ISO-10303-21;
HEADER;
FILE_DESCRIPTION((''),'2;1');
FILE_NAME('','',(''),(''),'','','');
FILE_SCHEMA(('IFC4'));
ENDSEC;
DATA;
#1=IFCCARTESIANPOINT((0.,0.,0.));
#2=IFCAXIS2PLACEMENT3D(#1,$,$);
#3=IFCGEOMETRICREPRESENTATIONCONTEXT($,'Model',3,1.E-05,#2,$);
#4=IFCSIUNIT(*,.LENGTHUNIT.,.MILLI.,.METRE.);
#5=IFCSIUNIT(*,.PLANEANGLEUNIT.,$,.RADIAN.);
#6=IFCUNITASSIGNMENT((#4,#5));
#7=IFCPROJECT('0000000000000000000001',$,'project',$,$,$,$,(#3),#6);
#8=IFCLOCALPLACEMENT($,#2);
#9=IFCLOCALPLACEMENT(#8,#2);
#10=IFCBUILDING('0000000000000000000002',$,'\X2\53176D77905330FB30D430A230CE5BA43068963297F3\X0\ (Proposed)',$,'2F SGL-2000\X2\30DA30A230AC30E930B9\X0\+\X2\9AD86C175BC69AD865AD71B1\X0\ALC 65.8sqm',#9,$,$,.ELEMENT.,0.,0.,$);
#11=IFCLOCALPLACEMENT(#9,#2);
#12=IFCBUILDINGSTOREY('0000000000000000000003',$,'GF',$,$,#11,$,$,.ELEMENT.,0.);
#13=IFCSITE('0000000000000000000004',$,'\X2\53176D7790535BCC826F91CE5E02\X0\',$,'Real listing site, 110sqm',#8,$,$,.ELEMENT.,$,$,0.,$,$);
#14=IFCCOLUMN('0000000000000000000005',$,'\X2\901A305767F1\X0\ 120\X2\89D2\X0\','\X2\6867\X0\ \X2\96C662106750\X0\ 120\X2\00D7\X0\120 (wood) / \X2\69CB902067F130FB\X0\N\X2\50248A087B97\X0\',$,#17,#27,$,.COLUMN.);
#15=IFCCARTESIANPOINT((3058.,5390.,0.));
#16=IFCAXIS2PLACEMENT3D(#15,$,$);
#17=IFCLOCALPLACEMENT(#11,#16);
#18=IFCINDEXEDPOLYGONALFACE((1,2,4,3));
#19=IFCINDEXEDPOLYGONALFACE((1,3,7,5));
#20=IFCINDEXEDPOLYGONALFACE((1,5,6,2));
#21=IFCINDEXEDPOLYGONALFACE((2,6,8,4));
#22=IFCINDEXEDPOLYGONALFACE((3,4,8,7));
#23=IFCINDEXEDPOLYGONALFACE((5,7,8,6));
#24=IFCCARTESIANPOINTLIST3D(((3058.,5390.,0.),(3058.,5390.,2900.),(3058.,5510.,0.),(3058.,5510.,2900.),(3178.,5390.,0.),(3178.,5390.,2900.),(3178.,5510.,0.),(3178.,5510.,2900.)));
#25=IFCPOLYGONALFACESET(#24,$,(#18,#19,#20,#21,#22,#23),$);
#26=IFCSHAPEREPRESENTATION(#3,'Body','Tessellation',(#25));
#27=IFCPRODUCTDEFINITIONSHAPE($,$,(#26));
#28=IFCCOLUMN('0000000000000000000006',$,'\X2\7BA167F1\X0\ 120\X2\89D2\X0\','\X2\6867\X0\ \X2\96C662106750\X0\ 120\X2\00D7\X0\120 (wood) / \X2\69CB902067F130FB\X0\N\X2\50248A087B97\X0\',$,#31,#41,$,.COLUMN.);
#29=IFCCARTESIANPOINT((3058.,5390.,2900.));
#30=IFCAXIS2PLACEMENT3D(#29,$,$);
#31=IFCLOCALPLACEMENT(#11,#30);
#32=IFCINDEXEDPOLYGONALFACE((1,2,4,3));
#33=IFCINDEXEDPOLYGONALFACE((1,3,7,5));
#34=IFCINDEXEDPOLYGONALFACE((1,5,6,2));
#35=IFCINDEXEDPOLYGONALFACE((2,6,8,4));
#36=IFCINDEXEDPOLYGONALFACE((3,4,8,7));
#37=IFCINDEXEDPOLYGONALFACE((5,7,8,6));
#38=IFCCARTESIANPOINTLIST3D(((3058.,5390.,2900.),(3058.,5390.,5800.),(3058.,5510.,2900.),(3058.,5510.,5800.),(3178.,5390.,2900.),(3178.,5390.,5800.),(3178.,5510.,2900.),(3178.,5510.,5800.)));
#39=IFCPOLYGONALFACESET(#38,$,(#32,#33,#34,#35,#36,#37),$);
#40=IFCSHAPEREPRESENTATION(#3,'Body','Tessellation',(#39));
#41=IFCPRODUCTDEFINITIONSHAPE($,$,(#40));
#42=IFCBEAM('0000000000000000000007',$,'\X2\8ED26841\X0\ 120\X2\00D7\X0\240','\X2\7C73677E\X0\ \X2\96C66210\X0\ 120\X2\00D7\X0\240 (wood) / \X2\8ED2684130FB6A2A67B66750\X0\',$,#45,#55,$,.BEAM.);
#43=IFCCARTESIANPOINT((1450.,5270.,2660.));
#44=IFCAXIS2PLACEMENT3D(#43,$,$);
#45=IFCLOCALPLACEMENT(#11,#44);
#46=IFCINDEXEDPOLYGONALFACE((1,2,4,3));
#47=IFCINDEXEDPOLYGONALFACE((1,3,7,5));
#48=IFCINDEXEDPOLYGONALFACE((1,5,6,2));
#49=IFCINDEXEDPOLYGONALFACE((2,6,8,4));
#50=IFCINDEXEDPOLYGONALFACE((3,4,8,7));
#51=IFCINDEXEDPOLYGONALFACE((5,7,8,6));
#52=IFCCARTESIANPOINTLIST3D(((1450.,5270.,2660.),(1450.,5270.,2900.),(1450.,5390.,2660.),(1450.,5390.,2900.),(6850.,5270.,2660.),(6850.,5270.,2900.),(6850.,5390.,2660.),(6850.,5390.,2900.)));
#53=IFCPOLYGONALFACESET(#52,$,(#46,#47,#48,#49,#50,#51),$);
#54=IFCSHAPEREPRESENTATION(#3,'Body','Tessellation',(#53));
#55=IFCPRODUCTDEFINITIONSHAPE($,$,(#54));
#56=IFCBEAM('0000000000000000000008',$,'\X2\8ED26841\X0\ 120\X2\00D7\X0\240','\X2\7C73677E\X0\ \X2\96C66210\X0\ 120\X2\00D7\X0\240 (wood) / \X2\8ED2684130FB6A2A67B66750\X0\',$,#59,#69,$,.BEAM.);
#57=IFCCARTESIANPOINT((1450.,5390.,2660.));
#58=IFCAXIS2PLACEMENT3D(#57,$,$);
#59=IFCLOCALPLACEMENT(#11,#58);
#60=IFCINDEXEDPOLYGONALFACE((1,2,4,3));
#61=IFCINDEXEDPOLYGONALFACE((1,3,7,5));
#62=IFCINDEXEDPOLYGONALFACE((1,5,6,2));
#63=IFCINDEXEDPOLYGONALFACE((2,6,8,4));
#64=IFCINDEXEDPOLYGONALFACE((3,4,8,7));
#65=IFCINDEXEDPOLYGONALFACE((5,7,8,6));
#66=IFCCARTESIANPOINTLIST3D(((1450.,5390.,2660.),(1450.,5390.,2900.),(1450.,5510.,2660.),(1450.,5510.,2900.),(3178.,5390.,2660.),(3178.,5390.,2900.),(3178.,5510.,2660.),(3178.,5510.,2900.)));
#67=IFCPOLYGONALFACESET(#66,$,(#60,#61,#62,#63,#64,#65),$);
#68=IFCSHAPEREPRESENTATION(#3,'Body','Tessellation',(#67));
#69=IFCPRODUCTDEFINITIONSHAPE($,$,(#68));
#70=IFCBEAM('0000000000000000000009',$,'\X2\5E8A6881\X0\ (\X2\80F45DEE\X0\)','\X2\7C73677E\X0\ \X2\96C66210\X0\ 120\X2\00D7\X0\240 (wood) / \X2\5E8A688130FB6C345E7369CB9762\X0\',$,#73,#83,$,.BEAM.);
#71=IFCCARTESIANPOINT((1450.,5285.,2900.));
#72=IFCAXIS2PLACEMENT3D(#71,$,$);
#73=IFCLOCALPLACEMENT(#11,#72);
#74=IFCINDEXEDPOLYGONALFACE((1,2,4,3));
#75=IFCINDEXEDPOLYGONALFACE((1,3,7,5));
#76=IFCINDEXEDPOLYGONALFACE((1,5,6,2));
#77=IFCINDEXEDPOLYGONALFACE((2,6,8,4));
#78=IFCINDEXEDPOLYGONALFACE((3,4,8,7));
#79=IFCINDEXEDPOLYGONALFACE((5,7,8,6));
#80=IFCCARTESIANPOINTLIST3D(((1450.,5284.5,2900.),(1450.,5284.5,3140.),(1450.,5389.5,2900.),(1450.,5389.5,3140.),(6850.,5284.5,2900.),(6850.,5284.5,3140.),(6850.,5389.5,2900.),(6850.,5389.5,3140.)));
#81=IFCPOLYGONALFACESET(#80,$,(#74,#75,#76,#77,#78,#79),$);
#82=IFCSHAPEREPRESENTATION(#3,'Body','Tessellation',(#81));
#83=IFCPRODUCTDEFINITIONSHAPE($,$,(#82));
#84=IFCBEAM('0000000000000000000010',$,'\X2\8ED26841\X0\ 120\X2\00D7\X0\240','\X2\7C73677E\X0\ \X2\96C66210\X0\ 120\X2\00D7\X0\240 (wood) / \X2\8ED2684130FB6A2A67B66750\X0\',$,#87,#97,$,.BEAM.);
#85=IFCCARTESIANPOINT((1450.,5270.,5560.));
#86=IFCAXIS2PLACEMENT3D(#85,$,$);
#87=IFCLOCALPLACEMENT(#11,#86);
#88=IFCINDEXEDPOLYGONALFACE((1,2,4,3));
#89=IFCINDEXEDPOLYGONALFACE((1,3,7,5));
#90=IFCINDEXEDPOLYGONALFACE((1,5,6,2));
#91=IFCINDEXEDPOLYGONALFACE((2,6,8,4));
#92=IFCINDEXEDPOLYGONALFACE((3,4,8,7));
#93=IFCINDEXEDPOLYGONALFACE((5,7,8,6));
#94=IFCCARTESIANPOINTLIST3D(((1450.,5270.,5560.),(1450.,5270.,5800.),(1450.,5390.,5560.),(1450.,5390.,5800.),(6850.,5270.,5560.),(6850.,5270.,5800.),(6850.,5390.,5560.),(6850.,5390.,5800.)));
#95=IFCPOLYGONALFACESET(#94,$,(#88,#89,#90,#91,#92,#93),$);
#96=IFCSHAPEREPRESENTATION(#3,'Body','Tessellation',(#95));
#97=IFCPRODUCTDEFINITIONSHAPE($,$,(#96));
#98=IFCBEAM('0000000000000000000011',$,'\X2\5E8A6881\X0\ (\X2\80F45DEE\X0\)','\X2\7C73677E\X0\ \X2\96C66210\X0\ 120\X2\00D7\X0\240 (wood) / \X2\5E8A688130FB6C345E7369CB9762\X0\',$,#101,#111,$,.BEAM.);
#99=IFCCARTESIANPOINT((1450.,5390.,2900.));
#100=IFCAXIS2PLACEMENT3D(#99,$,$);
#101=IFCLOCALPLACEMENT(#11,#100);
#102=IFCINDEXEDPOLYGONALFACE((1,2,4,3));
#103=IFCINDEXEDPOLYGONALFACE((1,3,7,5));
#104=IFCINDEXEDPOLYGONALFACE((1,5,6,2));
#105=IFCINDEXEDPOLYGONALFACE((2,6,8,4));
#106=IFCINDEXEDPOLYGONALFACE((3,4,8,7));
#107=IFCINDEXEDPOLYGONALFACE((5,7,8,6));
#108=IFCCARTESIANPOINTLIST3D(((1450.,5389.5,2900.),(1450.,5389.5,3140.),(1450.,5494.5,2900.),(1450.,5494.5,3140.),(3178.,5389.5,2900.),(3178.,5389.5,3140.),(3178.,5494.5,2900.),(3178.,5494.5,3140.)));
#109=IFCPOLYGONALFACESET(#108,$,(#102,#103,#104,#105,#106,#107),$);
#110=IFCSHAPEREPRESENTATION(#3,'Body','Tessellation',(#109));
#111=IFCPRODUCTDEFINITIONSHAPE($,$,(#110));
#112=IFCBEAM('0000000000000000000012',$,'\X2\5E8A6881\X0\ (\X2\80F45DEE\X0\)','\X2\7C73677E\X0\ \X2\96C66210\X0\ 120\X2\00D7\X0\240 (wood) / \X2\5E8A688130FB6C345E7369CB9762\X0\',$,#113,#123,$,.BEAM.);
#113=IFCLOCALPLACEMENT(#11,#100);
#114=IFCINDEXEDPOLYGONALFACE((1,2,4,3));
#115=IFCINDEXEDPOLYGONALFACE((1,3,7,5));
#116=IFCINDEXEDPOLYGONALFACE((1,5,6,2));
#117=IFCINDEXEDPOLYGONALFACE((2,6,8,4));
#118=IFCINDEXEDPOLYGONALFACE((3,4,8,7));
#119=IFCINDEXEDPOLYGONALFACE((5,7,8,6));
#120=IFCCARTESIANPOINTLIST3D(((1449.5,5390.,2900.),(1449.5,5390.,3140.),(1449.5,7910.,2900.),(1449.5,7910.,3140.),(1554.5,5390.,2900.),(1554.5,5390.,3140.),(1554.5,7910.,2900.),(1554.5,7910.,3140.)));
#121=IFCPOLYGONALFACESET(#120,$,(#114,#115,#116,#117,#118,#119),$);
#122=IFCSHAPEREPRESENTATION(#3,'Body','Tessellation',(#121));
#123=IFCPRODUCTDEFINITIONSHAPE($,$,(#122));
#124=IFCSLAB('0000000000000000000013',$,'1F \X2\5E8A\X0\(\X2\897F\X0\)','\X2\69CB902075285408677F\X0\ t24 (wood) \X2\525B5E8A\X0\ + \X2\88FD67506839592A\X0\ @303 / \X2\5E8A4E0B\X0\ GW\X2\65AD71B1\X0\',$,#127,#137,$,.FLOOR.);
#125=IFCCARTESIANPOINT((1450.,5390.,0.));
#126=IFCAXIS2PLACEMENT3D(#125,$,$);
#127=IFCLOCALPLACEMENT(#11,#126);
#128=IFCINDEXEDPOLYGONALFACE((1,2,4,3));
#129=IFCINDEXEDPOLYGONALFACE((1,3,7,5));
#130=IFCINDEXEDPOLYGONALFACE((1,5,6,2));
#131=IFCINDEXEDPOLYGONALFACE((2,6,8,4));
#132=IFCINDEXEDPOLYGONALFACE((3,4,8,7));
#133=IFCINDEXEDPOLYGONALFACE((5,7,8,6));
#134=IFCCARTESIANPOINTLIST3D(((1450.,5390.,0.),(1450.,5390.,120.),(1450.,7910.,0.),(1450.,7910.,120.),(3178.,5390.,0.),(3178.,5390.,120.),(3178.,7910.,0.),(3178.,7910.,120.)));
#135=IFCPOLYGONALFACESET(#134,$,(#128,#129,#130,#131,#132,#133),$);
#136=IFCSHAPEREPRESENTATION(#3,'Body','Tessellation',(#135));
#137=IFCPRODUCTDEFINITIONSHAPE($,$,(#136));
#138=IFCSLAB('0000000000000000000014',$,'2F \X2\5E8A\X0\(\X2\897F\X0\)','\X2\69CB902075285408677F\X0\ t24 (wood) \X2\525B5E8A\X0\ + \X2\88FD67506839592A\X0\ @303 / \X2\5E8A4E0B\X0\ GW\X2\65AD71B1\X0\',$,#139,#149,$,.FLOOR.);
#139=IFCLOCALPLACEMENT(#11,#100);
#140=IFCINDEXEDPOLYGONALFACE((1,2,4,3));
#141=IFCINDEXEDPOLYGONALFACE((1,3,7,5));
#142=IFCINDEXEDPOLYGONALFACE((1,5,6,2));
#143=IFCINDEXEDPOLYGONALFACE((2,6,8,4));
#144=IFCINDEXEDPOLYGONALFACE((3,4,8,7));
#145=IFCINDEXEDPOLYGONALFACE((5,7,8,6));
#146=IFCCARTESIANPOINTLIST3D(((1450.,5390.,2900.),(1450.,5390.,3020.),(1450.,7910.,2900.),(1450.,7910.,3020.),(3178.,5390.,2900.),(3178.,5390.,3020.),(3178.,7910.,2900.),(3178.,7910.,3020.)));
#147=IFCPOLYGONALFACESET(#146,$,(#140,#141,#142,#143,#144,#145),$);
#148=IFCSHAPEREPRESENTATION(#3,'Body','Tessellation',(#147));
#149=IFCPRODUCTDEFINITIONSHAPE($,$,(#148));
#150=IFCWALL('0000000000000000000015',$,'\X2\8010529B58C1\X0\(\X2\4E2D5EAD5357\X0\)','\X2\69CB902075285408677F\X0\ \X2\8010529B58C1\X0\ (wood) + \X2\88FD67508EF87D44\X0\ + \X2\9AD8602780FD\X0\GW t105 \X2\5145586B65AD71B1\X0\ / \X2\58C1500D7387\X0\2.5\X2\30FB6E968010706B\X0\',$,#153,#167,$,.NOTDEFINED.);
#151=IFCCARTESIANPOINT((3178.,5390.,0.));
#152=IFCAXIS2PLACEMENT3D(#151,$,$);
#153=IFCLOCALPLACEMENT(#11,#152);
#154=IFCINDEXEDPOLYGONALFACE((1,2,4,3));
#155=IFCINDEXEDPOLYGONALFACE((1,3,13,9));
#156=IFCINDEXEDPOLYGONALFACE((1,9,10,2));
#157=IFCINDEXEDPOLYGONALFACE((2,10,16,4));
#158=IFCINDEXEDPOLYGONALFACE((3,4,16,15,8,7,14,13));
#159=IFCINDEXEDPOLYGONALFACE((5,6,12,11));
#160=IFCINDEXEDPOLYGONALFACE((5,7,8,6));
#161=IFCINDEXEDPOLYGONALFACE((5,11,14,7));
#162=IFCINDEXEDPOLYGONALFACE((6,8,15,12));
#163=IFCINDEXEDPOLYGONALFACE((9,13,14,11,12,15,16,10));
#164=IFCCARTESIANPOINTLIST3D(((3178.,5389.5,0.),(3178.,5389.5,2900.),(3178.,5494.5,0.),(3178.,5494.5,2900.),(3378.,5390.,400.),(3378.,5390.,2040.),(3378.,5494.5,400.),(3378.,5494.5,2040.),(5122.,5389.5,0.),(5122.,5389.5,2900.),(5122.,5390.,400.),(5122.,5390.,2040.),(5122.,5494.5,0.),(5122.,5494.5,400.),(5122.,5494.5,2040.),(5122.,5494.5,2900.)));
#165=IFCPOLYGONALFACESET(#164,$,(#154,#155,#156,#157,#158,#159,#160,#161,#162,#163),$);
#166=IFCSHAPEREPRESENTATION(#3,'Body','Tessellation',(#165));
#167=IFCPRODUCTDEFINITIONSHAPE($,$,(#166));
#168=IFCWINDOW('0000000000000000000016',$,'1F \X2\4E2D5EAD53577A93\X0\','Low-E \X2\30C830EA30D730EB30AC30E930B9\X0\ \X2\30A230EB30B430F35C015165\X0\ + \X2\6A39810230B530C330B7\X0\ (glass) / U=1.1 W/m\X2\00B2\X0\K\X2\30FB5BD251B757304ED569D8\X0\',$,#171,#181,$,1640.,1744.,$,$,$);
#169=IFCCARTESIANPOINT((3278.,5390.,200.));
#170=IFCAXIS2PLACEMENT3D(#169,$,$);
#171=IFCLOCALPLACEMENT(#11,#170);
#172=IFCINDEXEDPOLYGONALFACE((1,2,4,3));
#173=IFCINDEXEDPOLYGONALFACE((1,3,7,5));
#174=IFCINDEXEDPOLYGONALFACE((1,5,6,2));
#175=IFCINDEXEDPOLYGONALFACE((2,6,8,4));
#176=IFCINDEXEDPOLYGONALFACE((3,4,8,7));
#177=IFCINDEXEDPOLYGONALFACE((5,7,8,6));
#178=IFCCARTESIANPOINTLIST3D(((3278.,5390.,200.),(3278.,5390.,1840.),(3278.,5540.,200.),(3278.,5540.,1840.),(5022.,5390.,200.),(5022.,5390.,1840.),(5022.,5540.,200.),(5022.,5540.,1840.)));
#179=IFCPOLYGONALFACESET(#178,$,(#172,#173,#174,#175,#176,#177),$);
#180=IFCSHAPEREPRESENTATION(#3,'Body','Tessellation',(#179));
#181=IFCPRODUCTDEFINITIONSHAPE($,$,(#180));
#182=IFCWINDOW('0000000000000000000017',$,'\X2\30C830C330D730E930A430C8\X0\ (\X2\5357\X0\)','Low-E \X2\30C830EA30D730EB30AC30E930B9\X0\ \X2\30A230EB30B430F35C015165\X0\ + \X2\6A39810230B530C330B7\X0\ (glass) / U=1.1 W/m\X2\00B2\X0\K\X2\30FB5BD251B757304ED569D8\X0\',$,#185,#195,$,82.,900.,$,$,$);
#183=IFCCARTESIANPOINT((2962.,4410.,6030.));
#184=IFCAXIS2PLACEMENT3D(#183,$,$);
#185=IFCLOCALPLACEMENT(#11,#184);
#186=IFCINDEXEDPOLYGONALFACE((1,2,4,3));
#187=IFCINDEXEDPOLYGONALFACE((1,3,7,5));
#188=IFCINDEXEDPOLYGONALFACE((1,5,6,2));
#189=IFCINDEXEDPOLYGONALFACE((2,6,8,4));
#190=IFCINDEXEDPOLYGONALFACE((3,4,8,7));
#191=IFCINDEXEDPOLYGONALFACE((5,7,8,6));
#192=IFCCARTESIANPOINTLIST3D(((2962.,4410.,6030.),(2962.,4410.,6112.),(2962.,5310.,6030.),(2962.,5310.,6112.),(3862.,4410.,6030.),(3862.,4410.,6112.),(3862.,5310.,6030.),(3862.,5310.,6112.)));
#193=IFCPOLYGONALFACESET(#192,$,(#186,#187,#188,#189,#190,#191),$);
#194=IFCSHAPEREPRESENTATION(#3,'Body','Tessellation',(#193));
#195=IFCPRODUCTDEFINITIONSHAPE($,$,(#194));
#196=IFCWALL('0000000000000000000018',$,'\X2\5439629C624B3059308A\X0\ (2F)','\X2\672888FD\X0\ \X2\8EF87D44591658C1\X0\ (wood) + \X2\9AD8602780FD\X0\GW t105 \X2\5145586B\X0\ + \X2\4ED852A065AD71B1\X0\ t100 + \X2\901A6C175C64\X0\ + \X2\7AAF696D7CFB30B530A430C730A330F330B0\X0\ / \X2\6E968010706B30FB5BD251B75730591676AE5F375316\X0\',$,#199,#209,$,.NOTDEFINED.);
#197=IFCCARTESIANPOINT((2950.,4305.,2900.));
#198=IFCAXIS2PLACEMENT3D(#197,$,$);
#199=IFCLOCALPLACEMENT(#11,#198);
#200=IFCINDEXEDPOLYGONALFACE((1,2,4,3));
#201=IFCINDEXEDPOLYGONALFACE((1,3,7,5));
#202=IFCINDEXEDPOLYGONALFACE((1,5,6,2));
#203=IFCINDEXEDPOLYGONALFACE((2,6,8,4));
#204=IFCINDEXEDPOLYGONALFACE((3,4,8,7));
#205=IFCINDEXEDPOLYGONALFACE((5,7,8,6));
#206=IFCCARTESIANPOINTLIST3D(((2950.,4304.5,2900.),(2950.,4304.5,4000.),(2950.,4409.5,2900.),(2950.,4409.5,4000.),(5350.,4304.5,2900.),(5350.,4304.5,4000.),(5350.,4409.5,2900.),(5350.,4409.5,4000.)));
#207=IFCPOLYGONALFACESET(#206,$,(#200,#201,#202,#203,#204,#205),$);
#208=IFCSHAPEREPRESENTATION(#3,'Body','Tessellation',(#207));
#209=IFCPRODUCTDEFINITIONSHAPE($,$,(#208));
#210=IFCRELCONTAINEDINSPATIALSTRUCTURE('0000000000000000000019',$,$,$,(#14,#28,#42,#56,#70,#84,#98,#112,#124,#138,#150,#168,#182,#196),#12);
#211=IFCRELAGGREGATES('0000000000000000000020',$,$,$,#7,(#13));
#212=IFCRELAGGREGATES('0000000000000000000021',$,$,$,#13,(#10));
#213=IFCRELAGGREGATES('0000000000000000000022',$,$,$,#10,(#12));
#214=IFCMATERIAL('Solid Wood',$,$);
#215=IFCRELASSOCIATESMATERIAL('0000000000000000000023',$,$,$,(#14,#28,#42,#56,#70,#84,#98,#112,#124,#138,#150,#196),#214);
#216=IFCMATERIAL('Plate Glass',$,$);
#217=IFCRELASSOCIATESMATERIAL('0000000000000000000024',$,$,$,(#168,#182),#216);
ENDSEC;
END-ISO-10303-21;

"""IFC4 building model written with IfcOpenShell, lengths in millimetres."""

from ifc_helpers import new_model, si_unit, frame, frame_2d, origin, place, context, project, spatial, rectangle, extrude, material, element, fill, save


model = new_model("IFC4")

# Units and contexts
model_context = context("Model", 3, precision=1e-05, world=origin())
ifc_project = project(units=[si_unit("LENGTHUNIT", "METRE", prefix="MILLI"), si_unit("PLANEANGLEUNIT", "RADIAN")], contexts=[model_context])

# Site, building, storey
site_placement = place(None, origin())
site = spatial("IfcSite", under=ifc_project, at=site_placement, Name="北海道富良野市", ObjectType="Real listing site, 110sqm", CompositionType="ELEMENT", RefElevation=0.0)
building_placement = place(site_placement, origin())
building = spatial("IfcBuilding", under=site, at=building_placement, Name="北海道・ピアノ室と防音 (Proposed)", ObjectType="2F SGL-2000ペアガラス+高気密高断熱ALC 65.8sqm", CompositionType="ELEMENT", ElevationOfRefHeight=0.0, ElevationOfTerrain=0.0)
storey_placement = place(building_placement, origin())
storey = spatial("IfcBuildingStorey", under=building, at=storey_placement, Name="GF", CompositionType="ELEMENT", Elevation=0.0)

# Columns
ifc_material_1 = material(Name="Solid Wood")
column_1_placement = place(storey_placement, frame((3058.0, 5390.0, 0.0)))
element("IfcColumn", 1, at=column_1_placement, inside=storey, material=ifc_material_1, Name="通し柱 120角", Description="桧 集成材 120×120 (wood) / 構造柱・N値計算", PredefinedType="COLUMN", context=model_context, shape_type="SweptSolid", body=[
    extrude(rectangle(XDim=120.0, YDim=120.0, at=frame_2d((60.0, 60.0))), frame((3058.0, 5390.0, 0.0)), (0.0, 0.0, 1.0), 2900.0),
])
column_2_placement = place(storey_placement, frame((3058.0, 5390.0, 2900.0)))
element("IfcColumn", 2, at=column_2_placement, inside=storey, material=ifc_material_1, Name="管柱 120角", Description="桧 集成材 120×120 (wood) / 構造柱・N値計算", PredefinedType="COLUMN", context=model_context, shape_type="SweptSolid", body=[
    extrude(rectangle(XDim=120.0, YDim=120.0, at=frame_2d((60.0, 60.0))), frame((3058.0, 5390.0, 2900.0)), (0.0, 0.0, 1.0), 2900.0),
])

# Beams
beam_1_placement = place(storey_placement, frame((1450.0, 5270.0, 2660.0)))
element("IfcBeam", 3, at=beam_1_placement, inside=storey, material=ifc_material_1, Name="軒桁 120×240", Description="米松 集成 120×240 (wood) / 軒桁・横架材", PredefinedType="BEAM", context=model_context, shape_type="SweptSolid", body=[
    extrude(rectangle(XDim=5400.0, YDim=120.0, at=frame_2d((2700.0, 60.0))), frame((1450.0, 5270.0, 2660.0)), (0.0, 0.0, 1.0), 240.0),
])
beam_2_placement = place(storey_placement, frame((1450.0, 5390.0, 2660.0)))
element("IfcBeam", 4, at=beam_2_placement, inside=storey, material=ifc_material_1, Name="軒桁 120×240", Description="米松 集成 120×240 (wood) / 軒桁・横架材", PredefinedType="BEAM", context=model_context, shape_type="SweptSolid", body=[
    extrude(rectangle(XDim=1728.0, YDim=120.0, at=frame_2d((864.0, 60.0))), frame((1450.0, 5390.0, 2660.0)), (0.0, 0.0, 1.0), 240.0),
])
beam_3_placement = place(storey_placement, frame((1450.0, 5285.0, 2900.0)))
element("IfcBeam", 5, at=beam_3_placement, inside=storey, material=ifc_material_1, Name="床梁 (胴差)", Description="米松 集成 120×240 (wood) / 床梁・水平構面", PredefinedType="BEAM", context=model_context, shape_type="SweptSolid", body=[
    extrude(rectangle(XDim=5400.0, YDim=105.0, at=frame_2d((2700.0, 52.0))), frame((1450.0, 5285.0, 2900.0)), (0.0, 0.0, 1.0), 240.0),
])
beam_4_placement = place(storey_placement, frame((1450.0, 5270.0, 5560.0)))
element("IfcBeam", 6, at=beam_4_placement, inside=storey, material=ifc_material_1, Name="軒桁 120×240", Description="米松 集成 120×240 (wood) / 軒桁・横架材", PredefinedType="BEAM", context=model_context, shape_type="SweptSolid", body=[
    extrude(rectangle(XDim=5400.0, YDim=120.0, at=frame_2d((2700.0, 60.0))), frame((1450.0, 5270.0, 5560.0)), (0.0, 0.0, 1.0), 240.0),
])
beam_5_placement = place(storey_placement, frame((1450.0, 5390.0, 2900.0)))
element("IfcBeam", 7, at=beam_5_placement, inside=storey, material=ifc_material_1, Name="床梁 (胴差)", Description="米松 集成 120×240 (wood) / 床梁・水平構面", PredefinedType="BEAM", context=model_context, shape_type="SweptSolid", body=[
    extrude(rectangle(XDim=1728.0, YDim=105.0, at=frame_2d((864.0, 52.0))), frame((1450.0, 5390.0, 2900.0)), (0.0, 0.0, 1.0), 240.0),
])
beam_6_placement = place(storey_placement, frame((1450.0, 5390.0, 2900.0)))
element("IfcBeam", 8, at=beam_6_placement, inside=storey, material=ifc_material_1, Name="床梁 (胴差)", Description="米松 集成 120×240 (wood) / 床梁・水平構面", PredefinedType="BEAM", context=model_context, shape_type="SweptSolid", body=[
    extrude(rectangle(XDim=105.0, YDim=2520.0, at=frame_2d((52.0, 1260.0))), frame((1450.0, 5390.0, 2900.0)), (0.0, 0.0, 1.0), 240.0),
])

# Slabs
slab_1_placement = place(storey_placement, frame((1450.0, 5390.0, 0.0)))
element("IfcSlab", 9, at=slab_1_placement, inside=storey, material=ifc_material_1, Name="1F 床(西)", Description="構造用合板 t24 (wood) 剛床 + 製材根太 @303 / 床下 GW断熱", PredefinedType="FLOOR", context=model_context, shape_type="SweptSolid", body=[
    extrude(rectangle(XDim=1728.0, YDim=2520.0, at=frame_2d((864.0, 1260.0))), frame((1450.0, 5390.0, 0.0)), (0.0, 0.0, 1.0), 120.0),
])
slab_2_placement = place(storey_placement, frame((1450.0, 5390.0, 2900.0)))
element("IfcSlab", 10, at=slab_2_placement, inside=storey, material=ifc_material_1, Name="2F 床(西)", Description="構造用合板 t24 (wood) 剛床 + 製材根太 @303 / 床下 GW断熱", PredefinedType="FLOOR", context=model_context, shape_type="SweptSolid", body=[
    extrude(rectangle(XDim=1728.0, YDim=2520.0, at=frame_2d((864.0, 1260.0))), frame((1450.0, 5390.0, 2900.0)), (0.0, 0.0, 1.0), 120.0),
])

# Wall, opening, window
wall_1_placement = place(storey_placement, frame((3178.0, 5390.0, 0.0)))
wall_1 = element("IfcWall", 11, at=wall_1_placement, inside=storey, material=ifc_material_1, Name="耐力壁(中庭南)", Description="構造用合板 耐力壁 (wood) + 製材軸組 + 高性能GW t105 充填断熱 / 壁倍率2.5・準耐火", PredefinedType="NOTDEFINED", context=model_context, shape_type="SweptSolid", body=[
    extrude(rectangle(XDim=1944.0, YDim=105.0, at=frame_2d((972.0, 52.0))), frame((3178.0, 5390.0, 0.0)), (0.0, 0.0, 1.0), 2900.0),
])
opening_placement = place(storey_placement, frame((3278.0, 5390.0, 200.0)))
opening = element("IfcOpeningElement", 12, at=opening_placement, cuts=wall_1, PredefinedType="NOTDEFINED", context=model_context, shape_type="SweptSolid", body=[
    extrude(rectangle(XDim=1744.0, YDim=150.0, at=frame_2d((872.0, 75.0))), frame((3278.0, 5390.0, 200.0)), (0.0, 0.0, 1.0), 1640.0),
])
ifc_material_2 = material(Name="Plate Glass")
window_1_placement = place(storey_placement, frame((3278.0, 5390.0, 200.0)))
window_1 = element("IfcWindow", 13, at=window_1_placement, inside=storey, material=ifc_material_2, Name="1F 中庭南窓", Description="Low-E トリプルガラス アルゴン封入 + 樹脂サッシ (glass) / U=1.1 W/m²K・寒冷地仕様", OverallHeight=1640.0, OverallWidth=1744.0, context=model_context, shape_type="SweptSolid", body=[
    extrude(rectangle(XDim=1744.0, YDim=150.0, at=frame_2d((872.0, 75.0))), frame((3278.0, 5390.0, 200.0)), (0.0, 0.0, 1.0), 1640.0),
])
fill(opening, window_1)

# Window
window_2_placement = place(storey_placement, frame((2962.0, 4410.0, 6030.0)))
element("IfcWindow", 14, at=window_2_placement, inside=storey, material=ifc_material_2, Name="トップライト (南)", Description="Low-E トリプルガラス アルゴン封入 + 樹脂サッシ (glass) / U=1.1 W/m²K・寒冷地仕様", OverallHeight=82.0, OverallWidth=900.0, context=model_context, shape_type="SweptSolid", body=[
    extrude(rectangle(XDim=900.0, YDim=900.0, at=frame_2d((450.0, 450.0))), frame((2962.0, 4410.0, 6030.0)), (0.0, 0.0, 1.0), 82.0),
])

# Wall
wall_2_placement = place(storey_placement, frame((2950.0, 4305.0, 2900.0)))
element("IfcWall", 15, at=wall_2_placement, inside=storey, material=ifc_material_1, Name="吹抜手すり (2F)", Description="木製 軸組外壁 (wood) + 高性能GW t105 充填 + 付加断熱 t100 + 通気層 + 窯業系サイディング / 準耐火・寒冷地外皮強化", PredefinedType="NOTDEFINED", context=model_context, shape_type="SweptSolid", body=[
    extrude(rectangle(XDim=2400.0, YDim=105.0, at=frame_2d((1200.0, 52.0))), frame((2950.0, 4305.0, 2900.0)), (0.0, 0.0, 1.0), 1100.0),
])

save(model, "model.ifc")
